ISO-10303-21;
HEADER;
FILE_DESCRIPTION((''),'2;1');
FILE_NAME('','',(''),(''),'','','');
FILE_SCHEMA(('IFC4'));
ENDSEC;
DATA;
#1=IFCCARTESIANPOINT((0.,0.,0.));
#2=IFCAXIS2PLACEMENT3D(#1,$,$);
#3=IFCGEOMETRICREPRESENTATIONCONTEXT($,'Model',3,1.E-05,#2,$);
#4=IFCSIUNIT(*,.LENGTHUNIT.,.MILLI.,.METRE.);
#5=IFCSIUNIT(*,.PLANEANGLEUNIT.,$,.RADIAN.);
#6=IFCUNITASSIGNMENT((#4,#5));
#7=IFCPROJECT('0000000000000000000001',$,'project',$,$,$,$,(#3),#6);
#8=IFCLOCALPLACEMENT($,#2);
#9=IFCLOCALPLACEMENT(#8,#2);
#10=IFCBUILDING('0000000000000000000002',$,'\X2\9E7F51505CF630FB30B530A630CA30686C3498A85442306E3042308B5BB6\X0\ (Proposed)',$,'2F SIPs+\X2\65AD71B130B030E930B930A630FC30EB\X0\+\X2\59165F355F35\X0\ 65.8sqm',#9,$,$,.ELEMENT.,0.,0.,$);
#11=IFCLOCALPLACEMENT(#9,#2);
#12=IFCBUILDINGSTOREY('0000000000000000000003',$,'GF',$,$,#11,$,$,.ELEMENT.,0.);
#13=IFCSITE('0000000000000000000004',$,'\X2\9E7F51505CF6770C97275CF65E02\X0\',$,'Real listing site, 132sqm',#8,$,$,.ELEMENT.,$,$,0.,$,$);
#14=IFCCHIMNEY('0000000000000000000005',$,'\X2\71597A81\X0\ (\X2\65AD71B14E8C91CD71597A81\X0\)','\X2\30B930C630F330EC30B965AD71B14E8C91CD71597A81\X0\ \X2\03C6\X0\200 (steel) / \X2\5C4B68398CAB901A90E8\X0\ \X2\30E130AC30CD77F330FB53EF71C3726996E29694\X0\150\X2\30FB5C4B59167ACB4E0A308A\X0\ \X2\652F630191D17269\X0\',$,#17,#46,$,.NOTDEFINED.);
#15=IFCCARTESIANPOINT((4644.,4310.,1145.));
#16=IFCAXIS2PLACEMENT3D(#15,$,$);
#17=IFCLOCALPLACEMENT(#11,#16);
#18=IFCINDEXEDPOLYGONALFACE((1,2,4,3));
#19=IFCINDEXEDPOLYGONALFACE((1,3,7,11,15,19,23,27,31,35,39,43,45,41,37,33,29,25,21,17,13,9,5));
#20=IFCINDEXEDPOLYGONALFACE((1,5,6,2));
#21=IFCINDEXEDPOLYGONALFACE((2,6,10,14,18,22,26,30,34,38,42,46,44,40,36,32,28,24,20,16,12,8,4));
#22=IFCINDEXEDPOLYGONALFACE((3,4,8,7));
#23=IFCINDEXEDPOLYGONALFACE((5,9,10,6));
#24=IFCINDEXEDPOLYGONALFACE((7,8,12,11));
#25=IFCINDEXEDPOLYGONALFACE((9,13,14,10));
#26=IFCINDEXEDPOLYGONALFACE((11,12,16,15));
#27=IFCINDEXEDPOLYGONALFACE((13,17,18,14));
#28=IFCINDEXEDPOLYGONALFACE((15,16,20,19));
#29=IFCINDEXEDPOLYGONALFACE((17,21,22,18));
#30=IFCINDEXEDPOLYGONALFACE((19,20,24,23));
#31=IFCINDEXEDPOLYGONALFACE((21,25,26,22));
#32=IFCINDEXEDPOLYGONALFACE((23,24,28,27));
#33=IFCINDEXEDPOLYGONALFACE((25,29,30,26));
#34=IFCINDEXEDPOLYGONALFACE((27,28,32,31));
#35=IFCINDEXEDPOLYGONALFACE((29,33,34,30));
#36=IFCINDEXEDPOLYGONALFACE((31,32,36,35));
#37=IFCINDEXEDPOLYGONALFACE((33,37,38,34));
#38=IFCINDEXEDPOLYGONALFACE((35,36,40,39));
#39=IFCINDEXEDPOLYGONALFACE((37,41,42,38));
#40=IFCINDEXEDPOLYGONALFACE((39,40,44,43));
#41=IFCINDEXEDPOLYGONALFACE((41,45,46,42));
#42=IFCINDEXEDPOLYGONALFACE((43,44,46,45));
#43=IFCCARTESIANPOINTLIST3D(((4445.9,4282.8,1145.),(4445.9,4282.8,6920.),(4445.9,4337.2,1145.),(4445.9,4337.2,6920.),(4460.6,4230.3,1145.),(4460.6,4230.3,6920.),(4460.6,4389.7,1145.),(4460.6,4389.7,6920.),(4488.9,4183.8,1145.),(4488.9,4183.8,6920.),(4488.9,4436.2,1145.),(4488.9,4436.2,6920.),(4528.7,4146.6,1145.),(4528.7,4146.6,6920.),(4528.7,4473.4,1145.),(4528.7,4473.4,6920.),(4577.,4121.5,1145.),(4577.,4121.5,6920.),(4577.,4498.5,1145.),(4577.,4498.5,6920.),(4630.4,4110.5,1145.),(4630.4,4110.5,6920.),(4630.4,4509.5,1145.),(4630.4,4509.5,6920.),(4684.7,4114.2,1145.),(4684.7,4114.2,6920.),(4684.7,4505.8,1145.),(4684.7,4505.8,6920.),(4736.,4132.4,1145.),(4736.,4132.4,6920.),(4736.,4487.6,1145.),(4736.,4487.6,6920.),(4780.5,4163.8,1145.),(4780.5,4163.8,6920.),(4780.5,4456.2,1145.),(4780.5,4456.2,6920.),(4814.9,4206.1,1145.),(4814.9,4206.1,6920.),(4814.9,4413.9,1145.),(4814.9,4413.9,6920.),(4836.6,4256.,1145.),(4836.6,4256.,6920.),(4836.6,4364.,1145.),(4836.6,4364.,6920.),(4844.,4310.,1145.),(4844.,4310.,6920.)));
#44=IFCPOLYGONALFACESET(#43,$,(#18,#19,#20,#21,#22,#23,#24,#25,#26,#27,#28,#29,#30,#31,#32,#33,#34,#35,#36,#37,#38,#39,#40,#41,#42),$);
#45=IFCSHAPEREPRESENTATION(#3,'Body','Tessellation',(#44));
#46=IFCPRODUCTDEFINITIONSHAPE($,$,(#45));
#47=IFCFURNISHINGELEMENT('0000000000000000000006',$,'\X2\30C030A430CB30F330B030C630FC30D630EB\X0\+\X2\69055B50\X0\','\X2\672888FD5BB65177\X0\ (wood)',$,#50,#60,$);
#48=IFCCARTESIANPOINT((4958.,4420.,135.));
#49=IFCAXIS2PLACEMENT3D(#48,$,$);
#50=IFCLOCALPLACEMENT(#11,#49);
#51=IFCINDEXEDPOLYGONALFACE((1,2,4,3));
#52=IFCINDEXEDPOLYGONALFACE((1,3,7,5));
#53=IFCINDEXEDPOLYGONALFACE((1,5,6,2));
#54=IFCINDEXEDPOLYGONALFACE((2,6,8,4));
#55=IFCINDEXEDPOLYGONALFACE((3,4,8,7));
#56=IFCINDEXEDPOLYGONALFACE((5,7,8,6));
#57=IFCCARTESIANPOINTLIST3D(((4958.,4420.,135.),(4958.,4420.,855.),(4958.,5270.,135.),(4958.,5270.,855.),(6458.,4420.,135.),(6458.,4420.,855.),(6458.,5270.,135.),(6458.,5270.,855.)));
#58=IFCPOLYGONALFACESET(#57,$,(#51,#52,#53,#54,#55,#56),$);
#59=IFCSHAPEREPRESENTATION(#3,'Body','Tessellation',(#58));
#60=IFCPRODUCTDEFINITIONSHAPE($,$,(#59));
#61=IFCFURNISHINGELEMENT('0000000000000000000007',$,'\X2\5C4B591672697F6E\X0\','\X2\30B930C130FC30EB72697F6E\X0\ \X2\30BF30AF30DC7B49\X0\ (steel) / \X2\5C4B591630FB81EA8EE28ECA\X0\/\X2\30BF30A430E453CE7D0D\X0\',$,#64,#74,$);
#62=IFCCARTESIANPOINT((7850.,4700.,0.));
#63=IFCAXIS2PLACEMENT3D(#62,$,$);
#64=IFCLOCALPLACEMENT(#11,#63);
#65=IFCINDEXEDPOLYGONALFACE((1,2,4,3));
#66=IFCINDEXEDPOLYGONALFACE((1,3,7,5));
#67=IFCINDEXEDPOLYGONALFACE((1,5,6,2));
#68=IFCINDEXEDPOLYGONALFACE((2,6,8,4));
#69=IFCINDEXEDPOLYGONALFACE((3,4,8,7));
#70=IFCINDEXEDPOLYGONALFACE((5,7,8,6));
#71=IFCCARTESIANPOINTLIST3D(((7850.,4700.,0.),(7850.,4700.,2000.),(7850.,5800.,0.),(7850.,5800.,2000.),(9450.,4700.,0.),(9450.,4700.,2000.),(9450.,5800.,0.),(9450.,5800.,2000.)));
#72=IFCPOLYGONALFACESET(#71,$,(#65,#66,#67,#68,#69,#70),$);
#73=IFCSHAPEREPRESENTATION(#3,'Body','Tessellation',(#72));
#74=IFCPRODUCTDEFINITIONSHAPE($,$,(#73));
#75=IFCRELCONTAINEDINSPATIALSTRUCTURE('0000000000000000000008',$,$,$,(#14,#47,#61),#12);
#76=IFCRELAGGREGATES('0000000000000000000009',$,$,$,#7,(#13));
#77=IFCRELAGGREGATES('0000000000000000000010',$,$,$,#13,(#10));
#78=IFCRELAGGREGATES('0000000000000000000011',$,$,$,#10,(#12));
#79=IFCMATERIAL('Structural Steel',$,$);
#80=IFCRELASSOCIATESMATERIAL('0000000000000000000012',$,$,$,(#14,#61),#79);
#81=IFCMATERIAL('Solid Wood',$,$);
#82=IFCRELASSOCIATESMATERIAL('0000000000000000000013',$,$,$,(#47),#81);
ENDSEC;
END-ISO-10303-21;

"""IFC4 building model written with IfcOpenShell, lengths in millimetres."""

from ifc_helpers import new_model, si_unit, frame, frame_2d, origin, origin_2d, place, context, project, spatial, rectangle, circle, extrude, material, element, save


model = new_model("IFC4")

# Units and contexts
model_context = context("Model", 3, precision=1e-05, world=origin())
ifc_project = project(units=[si_unit("LENGTHUNIT", "METRE", prefix="MILLI"), si_unit("PLANEANGLEUNIT", "RADIAN")], contexts=[model_context])

# Site, building, storey
site_placement = place(None, origin())
site = spatial("IfcSite", under=ifc_project, at=site_placement, Name="鹿児島県霧島市", ObjectType="Real listing site, 132sqm", CompositionType="ELEMENT", RefElevation=0.0)
building_placement = place(site_placement, origin())
building = spatial("IfcBuilding", under=site, at=building_placement, Name="鹿児島・サウナと水風呂のある家 (Proposed)", ObjectType="2F SIPs+断熱グラスウール+外張張 65.8sqm", CompositionType="ELEMENT", ElevationOfRefHeight=0.0, ElevationOfTerrain=0.0)
storey_placement = place(building_placement, origin())
storey = spatial("IfcBuildingStorey", under=building, at=storey_placement, Name="GF", CompositionType="ELEMENT", Elevation=0.0)

# Shared definitions
ifc_material_1 = material(Name="Solid Wood")

# Shared definitions
ifc_material_2 = material(Name="Structural Steel")

# Chimney
chimney_placement = place(storey_placement, frame((4644.0, 4310.0, 1145.0)))
element("IfcChimney", 1, at=chimney_placement, inside=storey, material=ifc_material_2, Name="煙突 (断熱二重煙突)", Description="ステンレス断熱二重煙突 φ200 (steel) / 屋根貫通部 メガネ石・可燃物離隔150・屋外立上り 支持金物", PredefinedType="NOTDEFINED", context=model_context, shape_type="SweptSolid", body=[
    extrude(circle(Radius=200.0, at=origin_2d()), frame((4644.0, 4310.0, 1145.0)), (0.0, 0.0, 1.0), 5775.0),
])

# Furnishing elements
furnishing_1_placement = place(storey_placement, frame((4958.0, 4420.0, 135.0)))
element("IfcFurnishingElement", 2, at=furnishing_1_placement, inside=storey, material=ifc_material_1, Name="ダイニングテーブル+椅子", Description="木製家具 (wood)", context=model_context, shape_type="SweptSolid", body=[
    extrude(rectangle(XDim=1500.0, YDim=850.0, at=frame_2d((750.0, 425.0))), frame((4958.0, 4420.0, 135.0)), (0.0, 0.0, 1.0), 720.0),
])
furnishing_2_placement = place(storey_placement, frame((7850.0, 4700.0, 0.0)))
element("IfcFurnishingElement", 3, at=furnishing_2_placement, inside=storey, material=ifc_material_2, Name="屋外物置", Description="スチール物置 タクボ等 (steel) / 屋外・自転車/タイヤ収納", context=model_context, shape_type="SweptSolid", body=[
    extrude(rectangle(XDim=1600.0, YDim=1100.0, at=frame_2d((800.0, 550.0))), frame((7850.0, 4700.0, 0.0)), (0.0, 0.0, 1.0), 2000.0),
])

save(model, "model.ifc")
